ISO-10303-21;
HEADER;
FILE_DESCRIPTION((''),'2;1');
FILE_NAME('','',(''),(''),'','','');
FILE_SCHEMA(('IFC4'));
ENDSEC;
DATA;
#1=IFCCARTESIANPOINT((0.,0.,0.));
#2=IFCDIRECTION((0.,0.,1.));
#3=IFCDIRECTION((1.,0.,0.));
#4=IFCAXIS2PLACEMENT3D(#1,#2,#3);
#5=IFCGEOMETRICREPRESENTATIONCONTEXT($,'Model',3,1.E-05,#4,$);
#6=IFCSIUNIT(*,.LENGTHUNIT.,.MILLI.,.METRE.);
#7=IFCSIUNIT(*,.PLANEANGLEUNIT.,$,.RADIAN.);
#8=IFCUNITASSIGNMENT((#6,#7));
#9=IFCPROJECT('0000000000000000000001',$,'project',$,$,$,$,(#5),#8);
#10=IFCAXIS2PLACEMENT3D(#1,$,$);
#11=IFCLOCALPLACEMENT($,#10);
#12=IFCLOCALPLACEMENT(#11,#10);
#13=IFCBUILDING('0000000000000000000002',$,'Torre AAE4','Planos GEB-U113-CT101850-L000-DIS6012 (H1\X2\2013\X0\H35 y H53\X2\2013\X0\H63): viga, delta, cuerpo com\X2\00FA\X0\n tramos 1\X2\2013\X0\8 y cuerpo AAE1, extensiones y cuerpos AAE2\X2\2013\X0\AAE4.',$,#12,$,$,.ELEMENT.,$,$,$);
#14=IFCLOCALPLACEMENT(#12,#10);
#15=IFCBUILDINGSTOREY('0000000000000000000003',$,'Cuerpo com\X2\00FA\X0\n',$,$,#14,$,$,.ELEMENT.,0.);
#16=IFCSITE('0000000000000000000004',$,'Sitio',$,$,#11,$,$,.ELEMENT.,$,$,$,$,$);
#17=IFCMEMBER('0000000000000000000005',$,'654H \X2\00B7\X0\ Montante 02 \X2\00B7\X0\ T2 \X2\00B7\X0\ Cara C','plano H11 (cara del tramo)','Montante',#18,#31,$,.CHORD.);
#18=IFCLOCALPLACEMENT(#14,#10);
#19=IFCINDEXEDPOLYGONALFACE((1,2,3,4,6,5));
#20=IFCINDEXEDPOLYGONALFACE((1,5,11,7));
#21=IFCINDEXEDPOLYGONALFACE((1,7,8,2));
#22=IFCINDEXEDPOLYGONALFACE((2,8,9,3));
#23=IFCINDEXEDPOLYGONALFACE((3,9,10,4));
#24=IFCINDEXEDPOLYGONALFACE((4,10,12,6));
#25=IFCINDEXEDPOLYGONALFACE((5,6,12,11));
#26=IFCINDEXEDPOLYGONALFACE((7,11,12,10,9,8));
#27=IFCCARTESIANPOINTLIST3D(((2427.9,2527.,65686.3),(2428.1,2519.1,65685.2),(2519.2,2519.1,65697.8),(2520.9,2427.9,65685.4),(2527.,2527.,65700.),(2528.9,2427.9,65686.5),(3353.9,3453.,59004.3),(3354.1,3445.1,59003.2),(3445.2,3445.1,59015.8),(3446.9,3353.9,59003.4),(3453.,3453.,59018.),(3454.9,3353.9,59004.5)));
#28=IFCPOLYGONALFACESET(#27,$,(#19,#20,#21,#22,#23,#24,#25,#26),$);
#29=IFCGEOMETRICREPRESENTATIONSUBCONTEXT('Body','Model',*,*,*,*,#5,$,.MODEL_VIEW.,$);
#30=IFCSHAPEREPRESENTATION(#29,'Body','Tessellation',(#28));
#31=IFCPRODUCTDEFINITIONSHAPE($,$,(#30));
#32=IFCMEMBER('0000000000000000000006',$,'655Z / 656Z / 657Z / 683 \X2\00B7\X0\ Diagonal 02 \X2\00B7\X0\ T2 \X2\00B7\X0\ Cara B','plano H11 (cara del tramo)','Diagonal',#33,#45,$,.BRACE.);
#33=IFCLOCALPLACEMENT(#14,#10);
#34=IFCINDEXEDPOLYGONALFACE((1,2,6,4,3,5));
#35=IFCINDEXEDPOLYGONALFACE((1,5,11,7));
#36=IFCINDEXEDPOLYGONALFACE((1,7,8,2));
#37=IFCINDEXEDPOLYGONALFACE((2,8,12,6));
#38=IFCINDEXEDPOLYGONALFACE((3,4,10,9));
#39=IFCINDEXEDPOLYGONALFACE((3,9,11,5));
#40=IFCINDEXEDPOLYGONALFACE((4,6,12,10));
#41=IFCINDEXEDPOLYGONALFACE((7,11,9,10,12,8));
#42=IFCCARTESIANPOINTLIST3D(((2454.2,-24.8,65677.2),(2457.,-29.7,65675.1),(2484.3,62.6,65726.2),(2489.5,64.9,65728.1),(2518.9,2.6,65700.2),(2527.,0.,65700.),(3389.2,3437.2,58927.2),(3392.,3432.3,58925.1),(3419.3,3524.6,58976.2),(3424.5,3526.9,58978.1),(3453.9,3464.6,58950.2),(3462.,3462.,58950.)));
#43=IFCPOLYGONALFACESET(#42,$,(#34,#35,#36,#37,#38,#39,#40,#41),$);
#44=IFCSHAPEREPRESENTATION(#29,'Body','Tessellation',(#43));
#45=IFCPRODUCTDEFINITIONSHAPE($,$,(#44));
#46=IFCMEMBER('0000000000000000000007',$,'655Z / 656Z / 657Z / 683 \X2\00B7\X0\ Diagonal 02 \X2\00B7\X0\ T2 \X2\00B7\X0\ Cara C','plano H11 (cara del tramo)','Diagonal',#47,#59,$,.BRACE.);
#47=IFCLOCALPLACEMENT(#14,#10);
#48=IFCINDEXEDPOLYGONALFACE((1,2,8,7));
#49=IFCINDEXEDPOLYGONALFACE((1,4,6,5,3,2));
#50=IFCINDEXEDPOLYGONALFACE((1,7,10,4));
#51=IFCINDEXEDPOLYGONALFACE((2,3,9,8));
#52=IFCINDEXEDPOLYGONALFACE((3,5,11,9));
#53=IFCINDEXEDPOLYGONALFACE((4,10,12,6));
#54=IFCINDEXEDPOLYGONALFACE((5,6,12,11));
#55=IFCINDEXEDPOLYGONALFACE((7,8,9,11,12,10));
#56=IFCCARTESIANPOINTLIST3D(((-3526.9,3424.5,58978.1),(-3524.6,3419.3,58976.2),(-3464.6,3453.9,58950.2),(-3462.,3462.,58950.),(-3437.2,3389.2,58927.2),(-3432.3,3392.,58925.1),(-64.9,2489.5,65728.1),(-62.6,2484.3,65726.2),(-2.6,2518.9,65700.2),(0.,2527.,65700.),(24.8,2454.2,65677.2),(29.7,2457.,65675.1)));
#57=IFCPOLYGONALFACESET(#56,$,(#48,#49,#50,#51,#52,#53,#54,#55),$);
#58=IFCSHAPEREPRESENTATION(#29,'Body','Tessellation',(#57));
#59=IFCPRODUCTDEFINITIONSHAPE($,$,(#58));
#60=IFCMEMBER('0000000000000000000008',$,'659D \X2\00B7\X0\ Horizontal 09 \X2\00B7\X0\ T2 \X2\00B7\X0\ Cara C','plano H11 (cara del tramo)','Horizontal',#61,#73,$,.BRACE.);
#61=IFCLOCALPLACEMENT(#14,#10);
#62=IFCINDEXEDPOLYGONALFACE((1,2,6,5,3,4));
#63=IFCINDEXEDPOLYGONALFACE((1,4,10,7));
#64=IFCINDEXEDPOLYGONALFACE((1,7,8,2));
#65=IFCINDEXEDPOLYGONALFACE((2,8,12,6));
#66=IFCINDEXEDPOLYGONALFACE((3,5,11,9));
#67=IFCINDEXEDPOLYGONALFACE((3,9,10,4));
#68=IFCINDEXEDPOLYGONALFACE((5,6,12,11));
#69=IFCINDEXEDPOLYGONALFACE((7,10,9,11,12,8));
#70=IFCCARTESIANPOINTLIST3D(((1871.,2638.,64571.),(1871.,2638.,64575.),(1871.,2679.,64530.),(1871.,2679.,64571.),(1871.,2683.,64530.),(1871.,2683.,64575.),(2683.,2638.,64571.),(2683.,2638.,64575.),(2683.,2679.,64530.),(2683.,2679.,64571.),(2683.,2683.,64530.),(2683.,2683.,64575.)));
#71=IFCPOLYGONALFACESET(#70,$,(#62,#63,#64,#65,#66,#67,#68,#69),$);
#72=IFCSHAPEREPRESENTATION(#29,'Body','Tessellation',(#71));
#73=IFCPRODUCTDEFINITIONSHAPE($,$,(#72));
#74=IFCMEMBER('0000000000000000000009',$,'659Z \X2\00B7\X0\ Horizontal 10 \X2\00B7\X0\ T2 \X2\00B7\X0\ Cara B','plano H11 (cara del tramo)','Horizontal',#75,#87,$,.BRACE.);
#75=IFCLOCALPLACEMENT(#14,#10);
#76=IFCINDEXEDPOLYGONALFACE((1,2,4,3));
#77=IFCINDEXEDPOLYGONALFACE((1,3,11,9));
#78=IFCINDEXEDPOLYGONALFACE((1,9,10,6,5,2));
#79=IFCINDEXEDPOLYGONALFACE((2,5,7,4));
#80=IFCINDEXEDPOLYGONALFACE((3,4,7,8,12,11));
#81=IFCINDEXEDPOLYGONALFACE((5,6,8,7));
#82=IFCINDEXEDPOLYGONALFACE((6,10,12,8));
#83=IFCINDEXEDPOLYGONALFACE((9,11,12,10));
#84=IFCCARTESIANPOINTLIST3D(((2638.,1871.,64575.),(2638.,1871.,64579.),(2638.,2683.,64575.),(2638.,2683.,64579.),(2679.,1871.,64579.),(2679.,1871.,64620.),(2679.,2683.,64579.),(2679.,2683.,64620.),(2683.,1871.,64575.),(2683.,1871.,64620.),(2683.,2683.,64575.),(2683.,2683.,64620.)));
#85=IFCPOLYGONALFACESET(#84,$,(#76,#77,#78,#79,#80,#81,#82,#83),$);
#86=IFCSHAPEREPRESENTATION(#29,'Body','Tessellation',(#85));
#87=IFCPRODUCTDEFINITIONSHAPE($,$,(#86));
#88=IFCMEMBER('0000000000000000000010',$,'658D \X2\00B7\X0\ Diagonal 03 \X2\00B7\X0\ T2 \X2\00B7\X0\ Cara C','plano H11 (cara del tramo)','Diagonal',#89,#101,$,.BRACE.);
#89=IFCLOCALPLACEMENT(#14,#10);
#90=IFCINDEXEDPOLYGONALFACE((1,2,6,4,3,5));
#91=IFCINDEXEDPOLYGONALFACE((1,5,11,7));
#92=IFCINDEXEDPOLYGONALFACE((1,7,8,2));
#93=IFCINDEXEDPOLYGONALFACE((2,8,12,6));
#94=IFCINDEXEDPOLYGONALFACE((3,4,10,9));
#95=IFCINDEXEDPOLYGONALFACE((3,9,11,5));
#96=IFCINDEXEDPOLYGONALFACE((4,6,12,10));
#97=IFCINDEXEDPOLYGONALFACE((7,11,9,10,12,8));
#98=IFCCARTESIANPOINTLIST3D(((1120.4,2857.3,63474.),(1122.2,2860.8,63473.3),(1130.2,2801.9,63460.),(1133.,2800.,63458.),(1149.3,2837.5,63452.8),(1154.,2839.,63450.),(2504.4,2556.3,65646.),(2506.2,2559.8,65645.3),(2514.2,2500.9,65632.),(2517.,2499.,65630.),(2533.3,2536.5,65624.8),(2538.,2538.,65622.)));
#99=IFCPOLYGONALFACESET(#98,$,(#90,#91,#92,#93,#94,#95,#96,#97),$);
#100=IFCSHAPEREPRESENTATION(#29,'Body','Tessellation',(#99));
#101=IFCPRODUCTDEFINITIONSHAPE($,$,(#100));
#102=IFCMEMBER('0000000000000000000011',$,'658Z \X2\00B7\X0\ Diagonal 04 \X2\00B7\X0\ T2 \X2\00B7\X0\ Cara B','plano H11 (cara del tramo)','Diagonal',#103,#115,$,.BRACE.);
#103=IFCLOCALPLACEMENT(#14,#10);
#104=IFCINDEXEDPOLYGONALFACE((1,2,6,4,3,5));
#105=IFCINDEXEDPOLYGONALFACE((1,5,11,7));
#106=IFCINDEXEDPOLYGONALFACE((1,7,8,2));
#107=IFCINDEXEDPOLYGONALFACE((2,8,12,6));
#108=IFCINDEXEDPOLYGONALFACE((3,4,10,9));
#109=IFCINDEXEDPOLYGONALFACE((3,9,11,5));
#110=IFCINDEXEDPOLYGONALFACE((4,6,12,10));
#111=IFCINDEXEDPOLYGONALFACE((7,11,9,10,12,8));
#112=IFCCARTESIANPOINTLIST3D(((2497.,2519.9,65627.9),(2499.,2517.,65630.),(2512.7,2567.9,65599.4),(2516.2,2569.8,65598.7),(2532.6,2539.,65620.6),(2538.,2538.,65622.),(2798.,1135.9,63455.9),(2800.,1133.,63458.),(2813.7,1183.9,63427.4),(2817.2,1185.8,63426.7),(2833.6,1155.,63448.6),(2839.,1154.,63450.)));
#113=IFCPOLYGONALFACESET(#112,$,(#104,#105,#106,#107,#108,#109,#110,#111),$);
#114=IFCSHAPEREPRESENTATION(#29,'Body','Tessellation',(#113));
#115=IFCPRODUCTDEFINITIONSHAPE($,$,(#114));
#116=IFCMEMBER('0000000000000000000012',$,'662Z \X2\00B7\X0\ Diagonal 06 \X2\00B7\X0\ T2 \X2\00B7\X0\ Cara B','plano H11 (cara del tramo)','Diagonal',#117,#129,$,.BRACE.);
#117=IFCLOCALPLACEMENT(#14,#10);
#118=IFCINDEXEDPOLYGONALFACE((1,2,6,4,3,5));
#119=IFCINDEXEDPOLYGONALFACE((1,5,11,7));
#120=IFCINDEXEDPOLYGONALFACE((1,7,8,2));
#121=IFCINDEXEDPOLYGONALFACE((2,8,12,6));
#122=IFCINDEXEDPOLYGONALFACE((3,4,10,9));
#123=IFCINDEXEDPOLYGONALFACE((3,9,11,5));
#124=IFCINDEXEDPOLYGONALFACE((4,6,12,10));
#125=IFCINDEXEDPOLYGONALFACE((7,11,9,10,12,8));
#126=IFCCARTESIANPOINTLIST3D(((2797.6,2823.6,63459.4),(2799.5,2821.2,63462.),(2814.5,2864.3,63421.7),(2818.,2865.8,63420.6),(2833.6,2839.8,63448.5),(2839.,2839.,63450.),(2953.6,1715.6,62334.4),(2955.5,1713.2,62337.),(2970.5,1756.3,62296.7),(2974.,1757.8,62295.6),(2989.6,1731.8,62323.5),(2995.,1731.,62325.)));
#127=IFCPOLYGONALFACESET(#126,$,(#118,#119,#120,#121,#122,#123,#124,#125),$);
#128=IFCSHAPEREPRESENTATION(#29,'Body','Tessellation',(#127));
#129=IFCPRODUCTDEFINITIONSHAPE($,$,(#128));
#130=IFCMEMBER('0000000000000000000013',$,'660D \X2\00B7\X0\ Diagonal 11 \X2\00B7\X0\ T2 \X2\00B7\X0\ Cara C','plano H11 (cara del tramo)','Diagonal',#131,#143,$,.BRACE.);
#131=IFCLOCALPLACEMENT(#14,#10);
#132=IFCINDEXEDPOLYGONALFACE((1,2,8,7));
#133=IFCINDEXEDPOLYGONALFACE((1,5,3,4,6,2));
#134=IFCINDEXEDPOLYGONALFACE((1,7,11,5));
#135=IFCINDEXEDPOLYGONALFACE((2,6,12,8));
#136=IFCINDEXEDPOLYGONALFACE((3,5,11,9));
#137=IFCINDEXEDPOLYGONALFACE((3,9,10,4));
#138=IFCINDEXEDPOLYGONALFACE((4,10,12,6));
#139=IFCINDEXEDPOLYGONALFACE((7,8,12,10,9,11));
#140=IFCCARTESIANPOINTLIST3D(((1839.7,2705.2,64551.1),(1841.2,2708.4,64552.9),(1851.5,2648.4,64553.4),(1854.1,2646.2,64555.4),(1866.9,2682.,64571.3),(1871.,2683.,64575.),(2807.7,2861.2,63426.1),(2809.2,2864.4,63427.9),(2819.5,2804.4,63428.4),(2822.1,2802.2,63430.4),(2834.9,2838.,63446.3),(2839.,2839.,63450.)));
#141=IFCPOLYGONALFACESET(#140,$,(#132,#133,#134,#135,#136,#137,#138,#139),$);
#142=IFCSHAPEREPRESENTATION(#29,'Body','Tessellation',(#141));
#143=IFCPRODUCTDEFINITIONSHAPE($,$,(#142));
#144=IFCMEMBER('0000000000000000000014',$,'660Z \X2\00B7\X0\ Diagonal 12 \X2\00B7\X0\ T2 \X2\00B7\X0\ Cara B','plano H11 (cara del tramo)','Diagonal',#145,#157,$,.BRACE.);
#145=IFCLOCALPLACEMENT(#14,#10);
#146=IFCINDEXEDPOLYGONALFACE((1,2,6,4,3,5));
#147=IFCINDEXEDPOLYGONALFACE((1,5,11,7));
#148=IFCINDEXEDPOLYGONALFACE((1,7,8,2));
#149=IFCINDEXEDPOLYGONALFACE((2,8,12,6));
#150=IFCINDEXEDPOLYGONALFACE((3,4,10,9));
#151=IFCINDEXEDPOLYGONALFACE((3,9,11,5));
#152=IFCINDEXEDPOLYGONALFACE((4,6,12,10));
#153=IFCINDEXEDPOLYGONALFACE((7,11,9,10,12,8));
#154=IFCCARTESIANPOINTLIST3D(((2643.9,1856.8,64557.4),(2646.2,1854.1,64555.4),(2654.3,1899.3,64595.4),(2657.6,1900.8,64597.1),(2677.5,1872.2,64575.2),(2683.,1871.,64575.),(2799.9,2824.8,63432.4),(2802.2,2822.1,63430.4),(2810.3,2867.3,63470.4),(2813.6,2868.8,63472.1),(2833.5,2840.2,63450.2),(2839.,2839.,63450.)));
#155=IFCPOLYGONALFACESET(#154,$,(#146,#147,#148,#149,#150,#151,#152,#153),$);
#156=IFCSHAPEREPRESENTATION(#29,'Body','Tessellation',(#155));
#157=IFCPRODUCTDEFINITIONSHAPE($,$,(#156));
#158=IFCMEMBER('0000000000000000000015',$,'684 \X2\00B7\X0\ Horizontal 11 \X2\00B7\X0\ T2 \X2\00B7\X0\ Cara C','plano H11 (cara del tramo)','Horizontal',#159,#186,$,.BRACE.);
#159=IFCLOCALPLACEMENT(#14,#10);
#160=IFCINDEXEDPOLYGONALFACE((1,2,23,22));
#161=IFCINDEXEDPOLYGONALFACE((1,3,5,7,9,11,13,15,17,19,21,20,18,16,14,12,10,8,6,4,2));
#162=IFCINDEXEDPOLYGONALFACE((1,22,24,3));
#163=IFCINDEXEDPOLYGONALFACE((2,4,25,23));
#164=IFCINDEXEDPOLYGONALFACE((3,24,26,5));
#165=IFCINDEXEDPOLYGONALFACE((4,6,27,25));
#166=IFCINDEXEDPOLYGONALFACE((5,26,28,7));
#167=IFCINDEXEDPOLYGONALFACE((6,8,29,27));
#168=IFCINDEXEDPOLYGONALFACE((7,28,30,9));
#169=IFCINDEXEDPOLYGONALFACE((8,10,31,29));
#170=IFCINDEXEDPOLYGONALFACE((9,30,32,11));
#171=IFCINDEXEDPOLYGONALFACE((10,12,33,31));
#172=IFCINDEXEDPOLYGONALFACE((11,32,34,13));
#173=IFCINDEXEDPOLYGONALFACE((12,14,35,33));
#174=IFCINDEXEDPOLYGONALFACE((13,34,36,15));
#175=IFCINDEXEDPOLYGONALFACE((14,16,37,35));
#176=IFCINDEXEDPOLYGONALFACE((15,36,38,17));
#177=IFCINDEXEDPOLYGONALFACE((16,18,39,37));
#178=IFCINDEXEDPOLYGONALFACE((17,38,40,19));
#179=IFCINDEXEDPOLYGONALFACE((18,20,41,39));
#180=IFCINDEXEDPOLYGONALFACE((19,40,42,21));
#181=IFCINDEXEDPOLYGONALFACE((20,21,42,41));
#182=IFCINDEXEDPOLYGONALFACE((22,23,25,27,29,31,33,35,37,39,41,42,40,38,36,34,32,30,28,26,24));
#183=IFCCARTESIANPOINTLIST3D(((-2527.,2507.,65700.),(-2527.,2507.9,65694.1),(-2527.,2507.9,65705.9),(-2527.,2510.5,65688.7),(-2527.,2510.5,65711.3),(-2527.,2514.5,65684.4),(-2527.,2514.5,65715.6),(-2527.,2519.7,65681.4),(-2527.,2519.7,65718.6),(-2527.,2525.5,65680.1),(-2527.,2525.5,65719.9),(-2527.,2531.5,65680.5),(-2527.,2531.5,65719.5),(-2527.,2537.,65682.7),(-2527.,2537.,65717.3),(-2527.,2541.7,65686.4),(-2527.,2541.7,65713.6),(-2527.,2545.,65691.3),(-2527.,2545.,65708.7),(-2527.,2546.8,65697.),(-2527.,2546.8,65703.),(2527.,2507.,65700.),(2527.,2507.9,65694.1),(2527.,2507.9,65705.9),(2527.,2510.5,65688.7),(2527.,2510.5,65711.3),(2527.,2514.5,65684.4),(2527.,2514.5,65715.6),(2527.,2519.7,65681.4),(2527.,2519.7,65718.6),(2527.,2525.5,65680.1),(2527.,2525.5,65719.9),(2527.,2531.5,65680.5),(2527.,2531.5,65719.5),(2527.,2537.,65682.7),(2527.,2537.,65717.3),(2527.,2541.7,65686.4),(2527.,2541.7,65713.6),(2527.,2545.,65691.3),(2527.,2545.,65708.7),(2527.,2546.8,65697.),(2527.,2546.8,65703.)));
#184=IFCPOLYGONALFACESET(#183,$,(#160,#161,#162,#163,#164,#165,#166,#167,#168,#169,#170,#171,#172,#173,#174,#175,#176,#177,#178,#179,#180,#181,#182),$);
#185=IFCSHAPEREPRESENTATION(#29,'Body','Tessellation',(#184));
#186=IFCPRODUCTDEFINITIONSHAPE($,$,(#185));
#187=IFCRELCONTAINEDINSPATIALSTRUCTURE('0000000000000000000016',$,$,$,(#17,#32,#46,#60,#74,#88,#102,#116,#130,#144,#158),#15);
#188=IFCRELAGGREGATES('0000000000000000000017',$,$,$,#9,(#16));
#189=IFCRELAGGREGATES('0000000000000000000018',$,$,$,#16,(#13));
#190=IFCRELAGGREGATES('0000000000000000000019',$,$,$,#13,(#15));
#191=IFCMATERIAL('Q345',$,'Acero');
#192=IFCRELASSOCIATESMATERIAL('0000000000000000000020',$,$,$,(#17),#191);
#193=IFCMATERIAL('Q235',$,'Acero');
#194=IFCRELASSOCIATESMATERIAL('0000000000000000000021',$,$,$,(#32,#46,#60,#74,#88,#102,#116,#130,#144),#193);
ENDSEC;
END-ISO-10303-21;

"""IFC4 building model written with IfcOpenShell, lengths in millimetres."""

from ifc_helpers import new_model, si_unit, frame, frame_2d, origin, origin_with_axes, place, context, subcontext, project, spatial, circle, l_section, extrude, material, element, save


model = new_model("IFC4")

# Units and contexts
model_context = context("Model", 3, precision=1e-05, world=origin_with_axes())
body_context = subcontext(model_context, "Body", "Model", "MODEL_VIEW")
ifc_project = project(units=[si_unit("LENGTHUNIT", "METRE", prefix="MILLI"), si_unit("PLANEANGLEUNIT", "RADIAN")], contexts=[model_context])

# Site, building, storey
site_placement = place(None, origin())
site = spatial("IfcSite", under=ifc_project, at=site_placement, Name="Sitio", CompositionType="ELEMENT")
building_placement = place(site_placement, origin())
building = spatial("IfcBuilding", under=site, at=building_placement, Name="Torre AAE4", Description="Planos GEB-U113-CT101850-L000-DIS6012 (H1–H35 y H53–H63): viga, delta, cuerpo común tramos 1–8 y cuerpo AAE1, extensiones y cuerpos AAE2–AAE4.", CompositionType="ELEMENT")
storey_placement = place(building_placement, origin())
storey = spatial("IfcBuildingStorey", under=building, at=storey_placement, Name="Cuerpo común", CompositionType="ELEMENT", Elevation=0.0)

# Members
ifc_material_1 = material(Name="Q235", Category="Acero")
ifc_material_2 = material(Name="Q345", Category="Acero")
member_1_placement = place(storey_placement, frame((2527.0, 2527.0, 65700.0), z_axis=(0.135994, 0.135994, -0.981331), x_axis=(0.018668, -0.99071, -0.134707)))
element("IfcMember", 1, at=member_1_placement, inside=storey, material=ifc_material_2, Name="654H · Montante 02 · T2 · Cara C", Description="plano H11 (cara del tramo)", ObjectType="Montante", PredefinedType="CHORD", context=body_context, shape_type="SweptSolid", body=[
    extrude(l_section(Depth=100.0, Width=100.0, Thickness=8.0, at=frame_2d((50.0, 50.0))), None, (0.0, 0.0, 1.0), 6809.1),
])
for number, where, z_axis, x_axis, name in (
    (2, (2527.0, 0.0, 65700.0), (0.122327, 0.452937, -0.88311), (-0.874879, -0.370937, -0.311437), "655Z / 656Z / 657Z / 683 · Diagonal 02 · T2 · Cara B"),
    (3, (0.0, 2527.0, 65700.0), (-0.452937, 0.122327, -0.88311), (0.370937, -0.874879, -0.311437), "655Z / 656Z / 657Z / 683 · Diagonal 02 · T2 · Cara C"),
):
    element("IfcMember", number, at=place(storey_placement, frame(where, z_axis=z_axis, x_axis=x_axis)), inside=storey, material=ifc_material_1, Name=name, Description="plano H11 (cara del tramo)", ObjectType="Diagonal", PredefinedType="BRACE", context=body_context, shape_type="SweptSolid", body=[
        extrude(l_section(Depth=80.0, Width=80.0, Thickness=6.0, at=frame_2d((40.0, 40.0))), None, (0.0, 0.0, 1.0), 7643.4),
    ])
for number, where, z_axis, x_axis, name in (
    (4, (1871.0, 2683.0, 64575.0), (1.0, 0.0, 0.0), (0.0, -1.0, 0.0), "659D · Horizontal 09 · T2 · Cara C"),
    (5, (2683.0, 1871.0, 64575.0), (0.0, 1.0, 0.0), (-1.0, 0.0, 0.0), "659Z · Horizontal 10 · T2 · Cara B"),
):
    element("IfcMember", number, at=place(storey_placement, frame(where, z_axis=z_axis, x_axis=x_axis)), inside=storey, material=ifc_material_1, Name=name, Description="plano H11 (cara del tramo)", ObjectType="Horizontal", PredefinedType="BRACE", context=body_context, shape_type="SweptSolid", body=[
        extrude(l_section(Depth=45.0, Width=45.0, Thickness=4.0, at=frame_2d((22.5, 22.5))), None, (0.0, 0.0, 1.0), 812.0),
    ])
for number, where, z_axis, x_axis, name in (
    (6, (2538.0, 2538.0, 65622.0), (-0.533745, 0.116082, -0.83764), (-0.465896, -0.867013, 0.176717), "658D · Diagonal 03 · T2 · Cara C"),
    (7, (2538.0, 2538.0, 65622.0), (0.116082, -0.533745, -0.83764), (-0.867013, -0.465896, 0.176717), "658Z · Diagonal 04 · T2 · Cara B"),
):
    element("IfcMember", number, at=place(storey_placement, frame(where, z_axis=z_axis, x_axis=x_axis)), inside=storey, material=ifc_material_1, Name=name, Description="plano H11 (cara del tramo)", ObjectType="Diagonal", PredefinedType="BRACE", context=body_context, shape_type="SweptSolid", body=[
        extrude(l_section(Depth=45.0, Width=45.0, Thickness=4.0, at=frame_2d((22.5, 22.5))), None, (0.0, 0.0, 1.0), 2593.0),
    ])
member_2_placement = place(storey_placement, frame((2839.0, 2839.0, 63450.0), z_axis=(0.098317, -0.698304, -0.709018), x_axis=(-0.878588, -0.395503, 0.267696)))
element("IfcMember", 8, at=member_2_placement, inside=storey, material=ifc_material_1, Name="662Z · Diagonal 06 · T2 · Cara B", Description="plano H11 (cara del tramo)", ObjectType="Diagonal", PredefinedType="BRACE", context=body_context, shape_type="SweptSolid", body=[
    extrude(l_section(Depth=45.0, Width=45.0, Thickness=4.0, at=frame_2d((22.5, 22.5))), None, (0.0, 0.0, 1.0), 1586.7),
])
for number, where, z_axis, x_axis, name in (
    (9, (1871.0, 2683.0, 64575.0), (0.648659, 0.104536, -0.753866), (-0.3746, -0.818382, -0.435805), "660D · Diagonal 11 · T2 · Cara C"),
    (10, (2683.0, 1871.0, 64575.0), (0.104536, 0.648659, -0.753866), (-0.818382, -0.3746, -0.435805), "660Z · Diagonal 12 · T2 · Cara B"),
):
    element("IfcMember", number, at=place(storey_placement, frame(where, z_axis=z_axis, x_axis=x_axis)), inside=storey, material=ifc_material_1, Name=name, Description="plano H11 (cara del tramo)", ObjectType="Diagonal", PredefinedType="BRACE", context=body_context, shape_type="SweptSolid", body=[
        extrude(l_section(Depth=45.0, Width=45.0, Thickness=4.0, at=frame_2d((22.5, 22.5))), None, (0.0, 0.0, 1.0), 1492.3),
    ])
member_3_placement = place(storey_placement, frame((2527.0, 2527.0, 65700.0), z_axis=(-1.0, 0.0, 0.0), x_axis=(0.0, -1.0, 0.0)))
element("IfcMember", 11, at=member_3_placement, inside=storey, Name="684 · Horizontal 11 · T2 · Cara C", Description="plano H11 (cara del tramo)", ObjectType="Horizontal", PredefinedType="BRACE", context=body_context, shape_type="SweptSolid", body=[
    extrude(circle(Radius=20.0), None, (0.0, 0.0, 1.0), 5054.0),
])

save(model, "model.ifc")
